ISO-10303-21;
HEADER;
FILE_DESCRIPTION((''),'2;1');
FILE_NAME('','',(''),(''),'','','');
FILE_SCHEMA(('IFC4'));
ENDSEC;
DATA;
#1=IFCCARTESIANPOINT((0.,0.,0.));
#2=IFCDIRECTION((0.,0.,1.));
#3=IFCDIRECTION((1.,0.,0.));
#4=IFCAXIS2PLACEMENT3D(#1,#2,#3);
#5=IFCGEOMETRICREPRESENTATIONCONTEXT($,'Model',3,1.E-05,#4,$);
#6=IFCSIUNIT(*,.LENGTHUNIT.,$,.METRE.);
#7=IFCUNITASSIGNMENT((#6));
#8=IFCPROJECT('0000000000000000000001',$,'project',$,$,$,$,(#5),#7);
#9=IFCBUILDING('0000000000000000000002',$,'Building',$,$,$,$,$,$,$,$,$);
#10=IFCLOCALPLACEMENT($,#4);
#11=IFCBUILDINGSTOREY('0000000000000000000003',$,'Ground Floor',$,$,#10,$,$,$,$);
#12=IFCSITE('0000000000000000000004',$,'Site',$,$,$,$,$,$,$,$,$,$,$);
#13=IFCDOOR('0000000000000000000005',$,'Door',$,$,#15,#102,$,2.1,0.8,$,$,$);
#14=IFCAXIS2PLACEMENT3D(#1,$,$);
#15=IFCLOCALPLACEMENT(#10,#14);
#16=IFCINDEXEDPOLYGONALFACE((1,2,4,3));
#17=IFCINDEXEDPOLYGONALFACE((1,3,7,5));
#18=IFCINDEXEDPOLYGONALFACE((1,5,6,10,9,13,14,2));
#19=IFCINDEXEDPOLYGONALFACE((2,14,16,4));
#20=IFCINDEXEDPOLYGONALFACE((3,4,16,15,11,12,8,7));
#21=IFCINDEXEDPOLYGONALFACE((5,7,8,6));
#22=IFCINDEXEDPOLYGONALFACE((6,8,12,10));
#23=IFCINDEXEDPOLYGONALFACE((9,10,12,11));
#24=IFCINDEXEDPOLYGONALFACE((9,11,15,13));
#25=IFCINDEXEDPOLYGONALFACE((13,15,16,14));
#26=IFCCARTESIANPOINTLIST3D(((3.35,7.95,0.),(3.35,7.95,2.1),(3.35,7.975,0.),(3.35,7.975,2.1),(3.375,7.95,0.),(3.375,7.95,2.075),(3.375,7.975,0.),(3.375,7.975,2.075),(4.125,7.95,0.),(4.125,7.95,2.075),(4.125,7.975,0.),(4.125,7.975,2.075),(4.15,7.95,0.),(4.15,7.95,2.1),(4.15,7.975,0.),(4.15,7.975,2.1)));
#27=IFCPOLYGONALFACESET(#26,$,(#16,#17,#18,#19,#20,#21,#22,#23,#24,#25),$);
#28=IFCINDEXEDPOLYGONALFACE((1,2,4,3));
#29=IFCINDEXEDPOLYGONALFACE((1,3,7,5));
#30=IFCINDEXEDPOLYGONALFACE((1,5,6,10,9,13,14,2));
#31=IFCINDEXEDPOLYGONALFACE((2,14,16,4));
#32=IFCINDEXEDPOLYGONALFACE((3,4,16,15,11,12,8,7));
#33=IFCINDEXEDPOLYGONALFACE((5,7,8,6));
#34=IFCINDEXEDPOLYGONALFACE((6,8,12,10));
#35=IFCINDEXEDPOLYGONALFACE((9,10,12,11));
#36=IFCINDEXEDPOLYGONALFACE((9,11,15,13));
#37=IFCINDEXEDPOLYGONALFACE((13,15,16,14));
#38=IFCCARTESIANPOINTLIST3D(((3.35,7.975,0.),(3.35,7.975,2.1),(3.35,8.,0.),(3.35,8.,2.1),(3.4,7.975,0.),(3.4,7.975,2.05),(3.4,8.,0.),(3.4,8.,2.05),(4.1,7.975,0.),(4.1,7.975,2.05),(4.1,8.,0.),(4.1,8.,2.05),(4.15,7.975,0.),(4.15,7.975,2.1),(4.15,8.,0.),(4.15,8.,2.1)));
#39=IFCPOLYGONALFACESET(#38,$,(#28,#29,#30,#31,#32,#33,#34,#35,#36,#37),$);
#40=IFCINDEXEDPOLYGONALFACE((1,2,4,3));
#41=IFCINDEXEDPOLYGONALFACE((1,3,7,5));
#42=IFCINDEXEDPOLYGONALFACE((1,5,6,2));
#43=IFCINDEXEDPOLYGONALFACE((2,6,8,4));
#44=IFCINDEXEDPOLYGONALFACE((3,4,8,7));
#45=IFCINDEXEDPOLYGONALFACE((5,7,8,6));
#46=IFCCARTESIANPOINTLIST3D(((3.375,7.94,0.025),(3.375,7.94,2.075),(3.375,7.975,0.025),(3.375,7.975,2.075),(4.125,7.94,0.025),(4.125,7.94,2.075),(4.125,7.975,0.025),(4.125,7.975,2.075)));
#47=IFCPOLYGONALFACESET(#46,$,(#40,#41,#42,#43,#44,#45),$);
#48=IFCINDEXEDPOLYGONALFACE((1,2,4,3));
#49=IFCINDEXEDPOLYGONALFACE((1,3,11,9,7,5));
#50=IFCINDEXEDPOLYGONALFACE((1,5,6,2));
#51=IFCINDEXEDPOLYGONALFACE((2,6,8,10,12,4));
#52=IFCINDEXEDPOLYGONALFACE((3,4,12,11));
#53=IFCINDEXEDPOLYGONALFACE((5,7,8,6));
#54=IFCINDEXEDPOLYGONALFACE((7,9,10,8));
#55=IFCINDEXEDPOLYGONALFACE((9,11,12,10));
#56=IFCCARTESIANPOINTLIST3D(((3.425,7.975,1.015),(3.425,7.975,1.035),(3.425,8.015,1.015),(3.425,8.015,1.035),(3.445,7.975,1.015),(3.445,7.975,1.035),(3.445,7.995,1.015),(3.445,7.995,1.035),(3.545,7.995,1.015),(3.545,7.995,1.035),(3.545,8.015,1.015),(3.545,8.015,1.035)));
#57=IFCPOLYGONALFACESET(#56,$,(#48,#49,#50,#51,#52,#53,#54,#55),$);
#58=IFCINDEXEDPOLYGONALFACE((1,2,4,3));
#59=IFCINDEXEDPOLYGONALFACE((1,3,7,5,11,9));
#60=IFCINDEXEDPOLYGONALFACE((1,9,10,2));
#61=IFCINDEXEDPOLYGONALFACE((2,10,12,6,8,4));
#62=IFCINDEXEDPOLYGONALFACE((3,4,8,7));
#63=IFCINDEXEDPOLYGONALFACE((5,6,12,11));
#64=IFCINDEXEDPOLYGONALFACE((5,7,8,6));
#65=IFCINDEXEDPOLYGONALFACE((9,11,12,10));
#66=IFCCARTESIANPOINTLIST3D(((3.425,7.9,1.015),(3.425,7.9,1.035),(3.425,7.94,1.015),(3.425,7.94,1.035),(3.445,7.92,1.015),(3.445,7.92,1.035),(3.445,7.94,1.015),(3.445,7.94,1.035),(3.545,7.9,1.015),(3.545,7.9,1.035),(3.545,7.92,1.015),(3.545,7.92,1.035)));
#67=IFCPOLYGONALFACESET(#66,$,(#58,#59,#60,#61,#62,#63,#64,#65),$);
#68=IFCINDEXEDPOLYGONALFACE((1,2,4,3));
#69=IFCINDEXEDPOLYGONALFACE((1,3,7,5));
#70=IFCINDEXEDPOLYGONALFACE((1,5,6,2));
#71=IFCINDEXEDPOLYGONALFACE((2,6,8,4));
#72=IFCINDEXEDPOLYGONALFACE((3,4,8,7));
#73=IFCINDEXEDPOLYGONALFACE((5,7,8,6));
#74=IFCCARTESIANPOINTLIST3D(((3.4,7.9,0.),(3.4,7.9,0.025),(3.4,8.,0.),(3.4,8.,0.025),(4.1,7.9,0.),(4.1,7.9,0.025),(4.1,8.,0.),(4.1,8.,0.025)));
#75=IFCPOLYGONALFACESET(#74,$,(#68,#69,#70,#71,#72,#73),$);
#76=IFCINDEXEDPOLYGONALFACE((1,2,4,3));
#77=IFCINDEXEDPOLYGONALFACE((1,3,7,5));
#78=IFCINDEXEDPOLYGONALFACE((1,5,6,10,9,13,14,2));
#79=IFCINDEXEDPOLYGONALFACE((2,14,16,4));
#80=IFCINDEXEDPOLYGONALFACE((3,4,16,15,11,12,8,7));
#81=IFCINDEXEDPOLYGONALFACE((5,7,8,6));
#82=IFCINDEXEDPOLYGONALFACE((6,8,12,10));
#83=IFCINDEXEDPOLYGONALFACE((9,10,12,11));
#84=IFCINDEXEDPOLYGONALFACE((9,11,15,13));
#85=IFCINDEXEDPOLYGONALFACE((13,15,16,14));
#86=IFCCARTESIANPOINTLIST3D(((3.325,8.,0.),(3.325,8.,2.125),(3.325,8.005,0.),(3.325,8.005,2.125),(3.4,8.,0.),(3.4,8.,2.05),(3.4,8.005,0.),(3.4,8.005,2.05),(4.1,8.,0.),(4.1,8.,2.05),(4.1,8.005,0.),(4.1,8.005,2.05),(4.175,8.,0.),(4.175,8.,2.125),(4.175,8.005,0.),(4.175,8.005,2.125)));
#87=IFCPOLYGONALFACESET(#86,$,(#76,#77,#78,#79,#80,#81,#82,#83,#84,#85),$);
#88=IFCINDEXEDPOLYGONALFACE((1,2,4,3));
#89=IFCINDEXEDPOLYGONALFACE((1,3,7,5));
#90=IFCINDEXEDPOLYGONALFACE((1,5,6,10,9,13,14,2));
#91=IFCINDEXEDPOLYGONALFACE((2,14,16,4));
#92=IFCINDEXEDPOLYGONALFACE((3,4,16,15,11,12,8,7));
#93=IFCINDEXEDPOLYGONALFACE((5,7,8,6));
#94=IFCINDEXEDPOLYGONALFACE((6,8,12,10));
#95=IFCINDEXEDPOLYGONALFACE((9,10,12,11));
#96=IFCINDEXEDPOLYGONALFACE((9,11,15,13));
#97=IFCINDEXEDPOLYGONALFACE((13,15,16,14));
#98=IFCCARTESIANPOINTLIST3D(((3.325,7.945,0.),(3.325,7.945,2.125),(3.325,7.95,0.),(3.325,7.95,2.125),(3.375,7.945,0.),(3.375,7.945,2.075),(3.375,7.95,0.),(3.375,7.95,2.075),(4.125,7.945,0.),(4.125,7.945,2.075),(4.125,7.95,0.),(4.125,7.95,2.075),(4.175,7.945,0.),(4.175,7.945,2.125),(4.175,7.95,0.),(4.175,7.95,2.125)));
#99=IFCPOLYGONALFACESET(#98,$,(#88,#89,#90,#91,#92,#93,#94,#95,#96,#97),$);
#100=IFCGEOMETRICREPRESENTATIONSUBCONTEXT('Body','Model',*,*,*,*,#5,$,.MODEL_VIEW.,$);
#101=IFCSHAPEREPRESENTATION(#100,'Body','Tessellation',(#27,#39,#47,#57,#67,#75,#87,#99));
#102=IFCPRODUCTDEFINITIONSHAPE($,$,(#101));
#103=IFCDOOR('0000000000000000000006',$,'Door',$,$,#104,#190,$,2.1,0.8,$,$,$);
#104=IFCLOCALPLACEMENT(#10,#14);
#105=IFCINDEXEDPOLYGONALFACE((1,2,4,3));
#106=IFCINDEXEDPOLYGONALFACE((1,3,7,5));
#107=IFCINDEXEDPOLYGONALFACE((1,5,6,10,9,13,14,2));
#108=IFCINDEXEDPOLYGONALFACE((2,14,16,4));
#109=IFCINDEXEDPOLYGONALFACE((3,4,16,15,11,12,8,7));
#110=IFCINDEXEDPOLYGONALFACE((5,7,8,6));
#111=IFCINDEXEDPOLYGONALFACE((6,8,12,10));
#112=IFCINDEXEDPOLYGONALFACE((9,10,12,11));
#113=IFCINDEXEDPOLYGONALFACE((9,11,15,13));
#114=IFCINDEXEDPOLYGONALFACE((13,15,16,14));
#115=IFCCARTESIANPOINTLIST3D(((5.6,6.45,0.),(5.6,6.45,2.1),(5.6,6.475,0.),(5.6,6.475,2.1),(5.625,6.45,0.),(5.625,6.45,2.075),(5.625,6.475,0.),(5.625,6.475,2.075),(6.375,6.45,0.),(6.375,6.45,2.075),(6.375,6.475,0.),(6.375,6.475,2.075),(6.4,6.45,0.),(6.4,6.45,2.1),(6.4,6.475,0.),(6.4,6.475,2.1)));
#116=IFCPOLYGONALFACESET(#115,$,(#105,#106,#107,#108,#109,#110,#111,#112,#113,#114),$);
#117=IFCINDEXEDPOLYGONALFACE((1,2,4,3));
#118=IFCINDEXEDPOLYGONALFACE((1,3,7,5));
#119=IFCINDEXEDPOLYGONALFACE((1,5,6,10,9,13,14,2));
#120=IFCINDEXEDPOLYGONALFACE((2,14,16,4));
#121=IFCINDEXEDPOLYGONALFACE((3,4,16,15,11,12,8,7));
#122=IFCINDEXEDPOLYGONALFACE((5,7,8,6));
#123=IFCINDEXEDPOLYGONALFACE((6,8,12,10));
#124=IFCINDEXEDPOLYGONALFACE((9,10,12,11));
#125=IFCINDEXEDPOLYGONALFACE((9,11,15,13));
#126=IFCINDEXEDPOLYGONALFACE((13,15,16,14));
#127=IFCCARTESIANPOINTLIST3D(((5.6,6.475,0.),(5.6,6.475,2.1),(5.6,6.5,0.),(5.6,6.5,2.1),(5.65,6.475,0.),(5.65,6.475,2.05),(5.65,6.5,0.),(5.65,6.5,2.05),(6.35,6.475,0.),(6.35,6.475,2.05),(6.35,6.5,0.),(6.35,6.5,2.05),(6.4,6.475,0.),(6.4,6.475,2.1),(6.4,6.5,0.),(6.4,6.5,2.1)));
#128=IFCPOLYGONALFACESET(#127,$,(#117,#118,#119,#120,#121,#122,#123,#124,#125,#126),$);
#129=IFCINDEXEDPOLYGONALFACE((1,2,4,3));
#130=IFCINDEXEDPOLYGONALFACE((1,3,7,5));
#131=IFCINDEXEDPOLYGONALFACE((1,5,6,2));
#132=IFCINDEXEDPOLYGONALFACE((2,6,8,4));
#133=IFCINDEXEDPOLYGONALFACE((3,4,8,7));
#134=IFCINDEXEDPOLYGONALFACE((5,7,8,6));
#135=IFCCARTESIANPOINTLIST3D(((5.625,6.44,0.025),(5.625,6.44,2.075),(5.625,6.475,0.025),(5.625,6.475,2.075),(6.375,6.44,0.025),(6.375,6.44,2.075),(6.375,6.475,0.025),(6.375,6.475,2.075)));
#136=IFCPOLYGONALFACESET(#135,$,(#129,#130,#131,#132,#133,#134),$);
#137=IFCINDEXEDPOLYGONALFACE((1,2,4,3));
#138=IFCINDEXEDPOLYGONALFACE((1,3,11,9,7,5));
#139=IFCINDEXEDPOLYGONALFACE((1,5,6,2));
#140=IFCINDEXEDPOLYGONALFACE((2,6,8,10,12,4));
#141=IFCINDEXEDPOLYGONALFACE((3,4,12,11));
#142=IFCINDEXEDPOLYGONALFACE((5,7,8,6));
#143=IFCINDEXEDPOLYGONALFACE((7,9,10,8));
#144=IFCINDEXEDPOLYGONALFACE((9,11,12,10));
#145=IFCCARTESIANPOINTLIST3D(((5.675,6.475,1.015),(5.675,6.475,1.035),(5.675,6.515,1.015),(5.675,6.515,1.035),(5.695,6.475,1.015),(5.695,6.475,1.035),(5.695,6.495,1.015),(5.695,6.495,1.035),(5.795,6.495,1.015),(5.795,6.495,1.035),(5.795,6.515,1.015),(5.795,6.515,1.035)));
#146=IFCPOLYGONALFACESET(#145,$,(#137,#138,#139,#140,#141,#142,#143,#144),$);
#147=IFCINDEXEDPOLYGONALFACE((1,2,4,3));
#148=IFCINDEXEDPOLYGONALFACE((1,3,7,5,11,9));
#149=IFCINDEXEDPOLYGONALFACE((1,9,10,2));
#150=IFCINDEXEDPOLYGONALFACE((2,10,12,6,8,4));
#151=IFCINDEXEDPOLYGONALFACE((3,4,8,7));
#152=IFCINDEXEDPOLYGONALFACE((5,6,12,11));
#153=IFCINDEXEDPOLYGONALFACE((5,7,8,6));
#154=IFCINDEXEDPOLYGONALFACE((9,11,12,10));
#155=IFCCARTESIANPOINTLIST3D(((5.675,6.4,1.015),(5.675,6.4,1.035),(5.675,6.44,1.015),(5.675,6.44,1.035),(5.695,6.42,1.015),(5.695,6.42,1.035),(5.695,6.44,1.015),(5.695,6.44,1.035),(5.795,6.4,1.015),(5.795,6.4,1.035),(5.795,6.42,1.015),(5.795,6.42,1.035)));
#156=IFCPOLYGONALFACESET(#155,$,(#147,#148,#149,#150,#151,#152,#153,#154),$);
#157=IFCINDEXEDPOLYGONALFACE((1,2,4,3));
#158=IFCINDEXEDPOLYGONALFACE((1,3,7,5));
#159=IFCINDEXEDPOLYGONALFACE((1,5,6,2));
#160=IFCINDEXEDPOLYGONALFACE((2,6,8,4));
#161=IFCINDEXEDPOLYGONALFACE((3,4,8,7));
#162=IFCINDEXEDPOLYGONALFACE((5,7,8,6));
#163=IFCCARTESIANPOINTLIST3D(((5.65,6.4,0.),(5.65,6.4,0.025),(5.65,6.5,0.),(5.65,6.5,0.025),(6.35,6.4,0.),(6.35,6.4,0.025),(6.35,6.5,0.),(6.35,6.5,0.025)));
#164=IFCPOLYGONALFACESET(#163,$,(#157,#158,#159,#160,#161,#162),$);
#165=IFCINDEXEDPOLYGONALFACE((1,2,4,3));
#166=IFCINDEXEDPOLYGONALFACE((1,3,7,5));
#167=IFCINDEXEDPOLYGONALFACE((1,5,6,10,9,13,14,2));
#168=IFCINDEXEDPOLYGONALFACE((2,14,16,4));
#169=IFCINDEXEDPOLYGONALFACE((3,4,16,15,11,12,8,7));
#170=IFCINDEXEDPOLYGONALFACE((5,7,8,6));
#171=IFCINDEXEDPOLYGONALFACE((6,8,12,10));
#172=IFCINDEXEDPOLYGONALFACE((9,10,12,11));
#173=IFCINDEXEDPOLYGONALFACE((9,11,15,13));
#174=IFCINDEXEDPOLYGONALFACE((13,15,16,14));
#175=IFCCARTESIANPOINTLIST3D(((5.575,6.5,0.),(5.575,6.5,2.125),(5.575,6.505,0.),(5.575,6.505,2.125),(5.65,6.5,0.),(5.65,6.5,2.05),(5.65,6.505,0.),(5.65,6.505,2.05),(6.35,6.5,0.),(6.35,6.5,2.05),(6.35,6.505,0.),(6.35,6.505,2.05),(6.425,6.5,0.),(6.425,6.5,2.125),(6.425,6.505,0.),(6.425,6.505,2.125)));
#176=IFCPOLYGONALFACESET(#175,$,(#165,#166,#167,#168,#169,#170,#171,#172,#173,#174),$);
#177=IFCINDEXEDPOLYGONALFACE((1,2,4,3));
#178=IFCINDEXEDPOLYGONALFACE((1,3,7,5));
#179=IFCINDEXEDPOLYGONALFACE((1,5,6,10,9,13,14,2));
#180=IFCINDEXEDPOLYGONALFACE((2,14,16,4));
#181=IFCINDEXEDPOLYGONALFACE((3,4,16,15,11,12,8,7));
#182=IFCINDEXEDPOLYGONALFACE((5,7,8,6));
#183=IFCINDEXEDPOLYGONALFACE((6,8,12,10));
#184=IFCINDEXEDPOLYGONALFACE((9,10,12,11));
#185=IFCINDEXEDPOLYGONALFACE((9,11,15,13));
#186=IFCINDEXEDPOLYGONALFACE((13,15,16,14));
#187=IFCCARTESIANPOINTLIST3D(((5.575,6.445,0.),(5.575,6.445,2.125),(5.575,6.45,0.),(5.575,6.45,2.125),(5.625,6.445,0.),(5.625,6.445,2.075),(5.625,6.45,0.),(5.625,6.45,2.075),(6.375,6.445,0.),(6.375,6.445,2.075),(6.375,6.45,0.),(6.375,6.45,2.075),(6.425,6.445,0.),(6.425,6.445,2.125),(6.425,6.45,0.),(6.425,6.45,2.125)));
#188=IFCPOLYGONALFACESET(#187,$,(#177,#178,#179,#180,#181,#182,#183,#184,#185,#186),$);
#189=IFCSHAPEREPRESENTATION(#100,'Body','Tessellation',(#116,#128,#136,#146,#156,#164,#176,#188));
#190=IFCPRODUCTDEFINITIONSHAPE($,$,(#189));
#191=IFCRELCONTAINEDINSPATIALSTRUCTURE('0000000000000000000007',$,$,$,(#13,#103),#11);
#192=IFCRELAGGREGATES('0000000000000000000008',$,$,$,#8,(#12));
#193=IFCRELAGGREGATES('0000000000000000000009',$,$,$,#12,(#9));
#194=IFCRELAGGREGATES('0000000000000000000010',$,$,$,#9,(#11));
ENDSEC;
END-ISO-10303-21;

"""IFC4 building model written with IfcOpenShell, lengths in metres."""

from ifc_helpers import new_model, si_unit, frame, origin_with_axes, place, context, subcontext, project, spatial, line, indexed_curve, outline, extrude, element, save


model = new_model("IFC4")

# Units and contexts
model_context = context("Model", 3, precision=1e-05, world=origin_with_axes())
body_context = subcontext(model_context, "Body", "Model", "MODEL_VIEW")
ifc_project = project(units=[si_unit("LENGTHUNIT", "METRE")], contexts=[model_context])

# Site, building, storey
site = spatial("IfcSite", under=ifc_project, Name="Site")
building = spatial("IfcBuilding", under=site, Name="Building")
storey_placement = place(None, origin_with_axes())
storey = spatial("IfcBuildingStorey", under=building, at=storey_placement, Name="Ground Floor")

# Doors
door_1_placement = place(storey_placement, frame((4.15, 8.0, 0.0), z_axis=(0.0, 0.0, 1.0), x_axis=(-1.0, 0.0, 0.0)))
element("IfcDoor", 1, at=door_1_placement, inside=storey, Name="Door", OverallHeight=2.1, OverallWidth=0.8, context=body_context, shape_type="SweptSolid", body=[
    extrude(outline(indexed_curve([(0.0, 0.0), (0.0, 2.1), (0.8, 2.1), (0.8, 0.0), (0.775, 0.0), (0.775, 2.075), (0.025, 2.075), (0.025, 0.0)], segments=[line(1, 2, 3, 4, 5, 6, 7, 8, 1)])), frame((0.0, 0.025, 0.0), z_axis=(0.0, -1.0, 0.0), x_axis=(1.0, 0.0, 0.0)), (0.0, 0.0, -1.0), 0.025),
    extrude(outline(indexed_curve([(0.0, 0.0), (0.0, 2.1), (0.8, 2.1), (0.8, 0.0), (0.75, 0.0), (0.75, 2.05), (0.05, 2.05), (0.05, 0.0)], segments=[line(1, 2, 3, 4, 5, 6, 7, 8, 1)])), frame((0.0, 0.0, 0.0), z_axis=(0.0, -1.0, 0.0), x_axis=(1.0, 0.0, 0.0)), (0.0, 0.0, -1.0), 0.025),
    extrude(outline(indexed_curve([(0.0, 0.0), (0.75, 0.0), (0.75, 0.035), (0.0, 0.035)], segments=[line(1, 2, 3, 4, 1)])), frame((0.025, 0.025, 0.025), z_axis=(0.0, 0.0, 1.0), x_axis=(1.0, 0.0, 0.0)), (0.0, 0.0, 1.0), 2.05),
    extrude(outline(indexed_curve([(0.0, 0.0), (0.0, -0.04), (-0.12, -0.04), (-0.12, -0.02), (-0.02, -0.02), (-0.02, 0.0)], segments=[line(1, 2, 3, 4, 5, 6, 1)])), frame((0.725, 0.025, 1.015), z_axis=(0.0, 0.0, 1.0), x_axis=(1.0, 0.0, 0.0)), (0.0, 0.0, 1.0), 0.02),
    extrude(outline(indexed_curve([(0.0, 0.0), (0.0, 0.04), (-0.12, 0.04), (-0.12, 0.02), (-0.02, 0.02), (-0.02, 0.0)], segments=[line(1, 2, 3, 4, 5, 6, 1)])), frame((0.725, 0.06, 1.015), z_axis=(0.0, 0.0, 1.0), x_axis=(1.0, 0.0, 0.0)), (0.0, 0.0, 1.0), 0.02),
    extrude(outline(indexed_curve([(0.0, 0.0), (0.7, 0.0), (0.7, 0.1), (0.0, 0.1)], segments=[line(1, 2, 3, 4, 1)])), frame((0.05, 0.0, 0.0), z_axis=(0.0, 0.0, 1.0), x_axis=(1.0, 0.0, 0.0)), (0.0, 0.0, 1.0), 0.025),
    extrude(outline(indexed_curve([(0.0, 0.0), (0.0, 2.125), (0.85, 2.125), (0.85, 0.0), (0.775, 0.0), (0.775, 2.05), (0.075, 2.05), (0.075, 0.0)], segments=[line(1, 2, 3, 4, 5, 6, 7, 8, 1)])), frame((-0.025, -0.005, 0.0), z_axis=(0.0, -1.0, 0.0), x_axis=(1.0, 0.0, 0.0)), (0.0, 0.0, -1.0), 0.005),
    extrude(outline(indexed_curve([(0.0, 0.0), (0.0, 2.125), (0.85, 2.125), (0.85, 0.0), (0.8, 0.0), (0.8, 2.075), (0.05, 2.075), (0.05, 0.0)], segments=[line(1, 2, 3, 4, 5, 6, 7, 8, 1)])), frame((-0.025, 0.05, 0.0), z_axis=(0.0, -1.0, 0.0), x_axis=(1.0, 0.0, 0.0)), (0.0, 0.0, -1.0), 0.005),
])
door_2_placement = place(storey_placement, frame((6.4, 6.5, 0.0), z_axis=(0.0, 0.0, 1.0), x_axis=(-1.0, 0.0, 0.0)))
element("IfcDoor", 2, at=door_2_placement, inside=storey, Name="Door", OverallHeight=2.1, OverallWidth=0.8, context=body_context, shape_type="SweptSolid", body=[
    extrude(outline(indexed_curve([(0.0, 0.0), (0.0, 2.1), (0.8, 2.1), (0.8, 0.0), (0.775, 0.0), (0.775, 2.075), (0.025, 2.075), (0.025, 0.0)], segments=[line(1, 2, 3, 4, 5, 6, 7, 8, 1)])), frame((0.0, 0.025, 0.0), z_axis=(0.0, -1.0, 0.0), x_axis=(1.0, 0.0, 0.0)), (0.0, 0.0, -1.0), 0.025),
    extrude(outline(indexed_curve([(0.0, 0.0), (0.0, 2.1), (0.8, 2.1), (0.8, 0.0), (0.75, 0.0), (0.75, 2.05), (0.05, 2.05), (0.05, 0.0)], segments=[line(1, 2, 3, 4, 5, 6, 7, 8, 1)])), frame((0.0, 0.0, 0.0), z_axis=(0.0, -1.0, 0.0), x_axis=(1.0, 0.0, 0.0)), (0.0, 0.0, -1.0), 0.025),
    extrude(outline(indexed_curve([(0.0, 0.0), (0.75, 0.0), (0.75, 0.035), (0.0, 0.035)], segments=[line(1, 2, 3, 4, 1)])), frame((0.025, 0.025, 0.025), z_axis=(0.0, 0.0, 1.0), x_axis=(1.0, 0.0, 0.0)), (0.0, 0.0, 1.0), 2.05),
    extrude(outline(indexed_curve([(0.0, 0.0), (0.0, -0.04), (-0.12, -0.04), (-0.12, -0.02), (-0.02, -0.02), (-0.02, 0.0)], segments=[line(1, 2, 3, 4, 5, 6, 1)])), frame((0.725, 0.025, 1.015), z_axis=(0.0, 0.0, 1.0), x_axis=(1.0, 0.0, 0.0)), (0.0, 0.0, 1.0), 0.02),
    extrude(outline(indexed_curve([(0.0, 0.0), (0.0, 0.04), (-0.12, 0.04), (-0.12, 0.02), (-0.02, 0.02), (-0.02, 0.0)], segments=[line(1, 2, 3, 4, 5, 6, 1)])), frame((0.725, 0.06, 1.015), z_axis=(0.0, 0.0, 1.0), x_axis=(1.0, 0.0, 0.0)), (0.0, 0.0, 1.0), 0.02),
    extrude(outline(indexed_curve([(0.0, 0.0), (0.7, 0.0), (0.7, 0.1), (0.0, 0.1)], segments=[line(1, 2, 3, 4, 1)])), frame((0.05, 0.0, 0.0), z_axis=(0.0, 0.0, 1.0), x_axis=(1.0, 0.0, 0.0)), (0.0, 0.0, 1.0), 0.025),
    extrude(outline(indexed_curve([(0.0, 0.0), (0.0, 2.125), (0.85, 2.125), (0.85, 0.0), (0.775, 0.0), (0.775, 2.05), (0.075, 2.05), (0.075, 0.0)], segments=[line(1, 2, 3, 4, 5, 6, 7, 8, 1)])), frame((-0.025, -0.005, 0.0), z_axis=(0.0, -1.0, 0.0), x_axis=(1.0, 0.0, 0.0)), (0.0, 0.0, -1.0), 0.005),
    extrude(outline(indexed_curve([(0.0, 0.0), (0.0, 2.125), (0.85, 2.125), (0.85, 0.0), (0.8, 0.0), (0.8, 2.075), (0.05, 2.075), (0.05, 0.0)], segments=[line(1, 2, 3, 4, 5, 6, 7, 8, 1)])), frame((-0.025, 0.05, 0.0), z_axis=(0.0, -1.0, 0.0), x_axis=(1.0, 0.0, 0.0)), (0.0, 0.0, -1.0), 0.005),
])

save(model, "model.ifc")
